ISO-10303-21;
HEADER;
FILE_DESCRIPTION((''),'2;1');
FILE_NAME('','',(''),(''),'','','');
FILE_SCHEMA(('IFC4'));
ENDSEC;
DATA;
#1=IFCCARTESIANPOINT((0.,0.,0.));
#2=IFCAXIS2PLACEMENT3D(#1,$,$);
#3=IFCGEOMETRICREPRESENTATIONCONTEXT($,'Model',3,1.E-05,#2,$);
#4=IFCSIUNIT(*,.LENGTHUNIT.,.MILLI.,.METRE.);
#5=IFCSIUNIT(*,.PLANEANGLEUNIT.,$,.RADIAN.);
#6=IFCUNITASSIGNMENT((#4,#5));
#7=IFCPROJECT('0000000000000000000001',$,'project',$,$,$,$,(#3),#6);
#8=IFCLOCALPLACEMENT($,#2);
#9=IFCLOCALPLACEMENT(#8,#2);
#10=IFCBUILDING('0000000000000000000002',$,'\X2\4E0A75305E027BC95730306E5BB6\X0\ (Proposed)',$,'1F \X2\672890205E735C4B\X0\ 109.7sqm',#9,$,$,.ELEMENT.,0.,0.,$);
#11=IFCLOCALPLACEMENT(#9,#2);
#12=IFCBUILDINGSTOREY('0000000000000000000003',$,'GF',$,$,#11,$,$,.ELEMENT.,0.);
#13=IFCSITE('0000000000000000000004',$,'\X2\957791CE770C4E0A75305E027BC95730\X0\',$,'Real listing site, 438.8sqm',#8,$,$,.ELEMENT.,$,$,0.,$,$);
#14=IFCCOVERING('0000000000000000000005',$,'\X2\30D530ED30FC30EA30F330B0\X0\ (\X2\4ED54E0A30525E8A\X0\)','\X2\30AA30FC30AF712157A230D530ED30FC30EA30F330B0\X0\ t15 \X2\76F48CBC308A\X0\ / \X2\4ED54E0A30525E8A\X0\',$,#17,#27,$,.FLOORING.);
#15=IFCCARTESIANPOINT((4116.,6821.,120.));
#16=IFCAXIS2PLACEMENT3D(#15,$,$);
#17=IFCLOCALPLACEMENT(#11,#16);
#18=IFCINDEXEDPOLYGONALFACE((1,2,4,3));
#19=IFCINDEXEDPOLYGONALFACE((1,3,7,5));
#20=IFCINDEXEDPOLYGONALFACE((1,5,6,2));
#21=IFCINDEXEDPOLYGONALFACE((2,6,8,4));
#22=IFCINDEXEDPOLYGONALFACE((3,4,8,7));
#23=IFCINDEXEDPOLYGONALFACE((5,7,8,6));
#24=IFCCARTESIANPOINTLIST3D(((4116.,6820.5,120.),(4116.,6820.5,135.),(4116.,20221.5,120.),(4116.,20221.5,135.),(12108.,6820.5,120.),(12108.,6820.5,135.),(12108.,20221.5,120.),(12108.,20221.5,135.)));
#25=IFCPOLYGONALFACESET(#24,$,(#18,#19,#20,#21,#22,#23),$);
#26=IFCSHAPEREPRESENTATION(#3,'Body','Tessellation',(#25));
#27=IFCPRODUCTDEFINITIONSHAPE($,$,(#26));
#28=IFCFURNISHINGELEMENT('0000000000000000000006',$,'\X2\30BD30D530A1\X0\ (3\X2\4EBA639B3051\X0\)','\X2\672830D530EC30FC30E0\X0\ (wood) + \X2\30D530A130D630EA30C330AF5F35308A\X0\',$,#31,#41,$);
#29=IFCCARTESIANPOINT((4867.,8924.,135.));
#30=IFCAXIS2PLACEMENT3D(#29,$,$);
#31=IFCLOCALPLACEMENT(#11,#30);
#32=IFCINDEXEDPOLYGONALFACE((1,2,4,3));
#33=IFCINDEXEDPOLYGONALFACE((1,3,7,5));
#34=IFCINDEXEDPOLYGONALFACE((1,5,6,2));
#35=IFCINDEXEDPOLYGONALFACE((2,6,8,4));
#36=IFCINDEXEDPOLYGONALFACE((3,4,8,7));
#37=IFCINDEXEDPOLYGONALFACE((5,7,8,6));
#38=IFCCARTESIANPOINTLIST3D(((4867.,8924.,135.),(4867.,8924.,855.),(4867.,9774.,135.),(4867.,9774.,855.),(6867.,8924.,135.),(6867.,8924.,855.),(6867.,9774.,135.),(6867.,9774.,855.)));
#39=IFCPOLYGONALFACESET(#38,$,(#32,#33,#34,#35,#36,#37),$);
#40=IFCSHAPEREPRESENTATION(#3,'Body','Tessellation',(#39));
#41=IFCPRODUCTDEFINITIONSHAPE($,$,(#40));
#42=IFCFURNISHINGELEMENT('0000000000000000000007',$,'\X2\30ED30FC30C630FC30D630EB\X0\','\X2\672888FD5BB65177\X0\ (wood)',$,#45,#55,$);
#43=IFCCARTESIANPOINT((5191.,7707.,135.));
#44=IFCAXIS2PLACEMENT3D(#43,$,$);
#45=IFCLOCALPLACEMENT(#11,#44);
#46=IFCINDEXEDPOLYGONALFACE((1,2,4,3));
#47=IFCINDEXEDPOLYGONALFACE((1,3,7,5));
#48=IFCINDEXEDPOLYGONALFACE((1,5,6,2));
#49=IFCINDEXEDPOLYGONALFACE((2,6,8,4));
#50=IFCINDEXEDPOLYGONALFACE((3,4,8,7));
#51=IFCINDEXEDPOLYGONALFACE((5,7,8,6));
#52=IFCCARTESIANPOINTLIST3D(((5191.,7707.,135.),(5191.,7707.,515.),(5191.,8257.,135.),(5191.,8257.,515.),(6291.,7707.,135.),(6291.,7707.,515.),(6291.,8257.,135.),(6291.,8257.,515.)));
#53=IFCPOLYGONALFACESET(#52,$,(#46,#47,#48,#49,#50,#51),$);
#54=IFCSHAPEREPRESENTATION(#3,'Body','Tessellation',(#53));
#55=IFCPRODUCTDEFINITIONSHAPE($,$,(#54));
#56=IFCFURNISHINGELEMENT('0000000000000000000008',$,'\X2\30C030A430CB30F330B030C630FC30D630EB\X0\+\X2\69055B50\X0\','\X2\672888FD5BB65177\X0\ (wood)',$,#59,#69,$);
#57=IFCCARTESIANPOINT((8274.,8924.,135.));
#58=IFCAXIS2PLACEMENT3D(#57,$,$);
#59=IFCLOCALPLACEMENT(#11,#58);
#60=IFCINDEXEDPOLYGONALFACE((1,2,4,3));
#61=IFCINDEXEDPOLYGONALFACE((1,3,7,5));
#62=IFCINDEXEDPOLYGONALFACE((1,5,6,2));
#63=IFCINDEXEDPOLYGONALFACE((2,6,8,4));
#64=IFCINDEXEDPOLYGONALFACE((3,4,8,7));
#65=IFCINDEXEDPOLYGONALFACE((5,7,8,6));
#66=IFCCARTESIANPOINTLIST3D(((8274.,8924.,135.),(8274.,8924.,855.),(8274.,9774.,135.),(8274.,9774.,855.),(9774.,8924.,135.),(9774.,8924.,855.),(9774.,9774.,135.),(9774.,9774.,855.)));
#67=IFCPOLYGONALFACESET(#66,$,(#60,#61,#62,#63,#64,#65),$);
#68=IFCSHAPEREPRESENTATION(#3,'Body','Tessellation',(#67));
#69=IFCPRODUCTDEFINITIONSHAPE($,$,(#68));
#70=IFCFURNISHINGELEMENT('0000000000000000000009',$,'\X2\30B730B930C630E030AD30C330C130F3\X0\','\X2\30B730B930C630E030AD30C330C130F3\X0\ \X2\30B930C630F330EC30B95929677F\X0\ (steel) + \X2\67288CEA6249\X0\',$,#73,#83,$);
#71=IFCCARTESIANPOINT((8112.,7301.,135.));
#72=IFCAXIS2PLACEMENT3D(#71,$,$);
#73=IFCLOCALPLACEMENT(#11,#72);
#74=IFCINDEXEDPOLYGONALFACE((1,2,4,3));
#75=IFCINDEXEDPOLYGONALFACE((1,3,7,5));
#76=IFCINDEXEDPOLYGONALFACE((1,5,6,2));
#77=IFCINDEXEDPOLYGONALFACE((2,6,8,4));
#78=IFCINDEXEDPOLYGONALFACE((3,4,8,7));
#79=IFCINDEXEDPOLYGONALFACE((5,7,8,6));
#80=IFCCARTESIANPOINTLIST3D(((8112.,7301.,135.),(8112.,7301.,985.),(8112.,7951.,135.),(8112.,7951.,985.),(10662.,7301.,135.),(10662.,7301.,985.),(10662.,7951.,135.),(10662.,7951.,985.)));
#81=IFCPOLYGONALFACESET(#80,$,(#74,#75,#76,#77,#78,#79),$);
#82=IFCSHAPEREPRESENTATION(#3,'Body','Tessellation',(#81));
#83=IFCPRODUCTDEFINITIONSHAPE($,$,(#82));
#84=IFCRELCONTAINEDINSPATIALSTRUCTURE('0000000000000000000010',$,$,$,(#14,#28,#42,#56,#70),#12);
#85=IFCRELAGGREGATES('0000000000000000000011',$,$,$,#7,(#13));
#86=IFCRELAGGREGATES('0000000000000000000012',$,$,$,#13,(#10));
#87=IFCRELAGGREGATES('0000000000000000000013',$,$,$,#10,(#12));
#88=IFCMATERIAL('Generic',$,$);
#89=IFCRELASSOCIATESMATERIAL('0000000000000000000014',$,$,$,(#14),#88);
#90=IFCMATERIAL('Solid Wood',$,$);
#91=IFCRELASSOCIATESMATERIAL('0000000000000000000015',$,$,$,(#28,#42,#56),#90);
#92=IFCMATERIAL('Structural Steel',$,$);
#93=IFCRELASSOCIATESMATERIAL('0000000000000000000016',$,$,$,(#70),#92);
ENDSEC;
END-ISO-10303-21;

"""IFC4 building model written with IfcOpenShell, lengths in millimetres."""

from ifc_helpers import new_model, si_unit, frame, frame_2d, origin, place, context, project, spatial, rectangle, extrude, material, element, save


model = new_model("IFC4")

# Units and contexts
model_context = context("Model", 3, precision=1e-05, world=origin())
ifc_project = project(units=[si_unit("LENGTHUNIT", "METRE", prefix="MILLI"), si_unit("PLANEANGLEUNIT", "RADIAN")], contexts=[model_context])

# Site, building, storey
site_placement = place(None, origin())
site = spatial("IfcSite", under=ifc_project, at=site_placement, Name="長野県上田市築地", ObjectType="Real listing site, 438.8sqm", CompositionType="ELEMENT", RefElevation=0.0)
building_placement = place(site_placement, origin())
building = spatial("IfcBuilding", under=site, at=building_placement, Name="上田市築地の家 (Proposed)", ObjectType="1F 木造平屋 109.7sqm", CompositionType="ELEMENT", ElevationOfRefHeight=0.0, ElevationOfTerrain=0.0)
storey_placement = place(building_placement, origin())
storey = spatial("IfcBuildingStorey", under=building, at=storey_placement, Name="GF", CompositionType="ELEMENT", Elevation=0.0)

# Shared definitions
ifc_material_1 = material(Name="Solid Wood")

# Shared definitions
ifc_material_2 = material(Name="Structural Steel")

# Covering
ifc_material_3 = material(Name="Generic")
covering_placement = place(storey_placement, frame((4116.0, 6821.0, 120.0)))
element("IfcCovering", 1, at=covering_placement, inside=storey, material=ifc_material_3, Name="フローリング (仕上げ床)", Description="オーク無垢フローリング t15 直貼り / 仕上げ床", PredefinedType="FLOORING", context=model_context, shape_type="SweptSolid", body=[
    extrude(rectangle(XDim=7992.0, YDim=13401.0, at=frame_2d((3996.0, 6700.0))), frame((4116.0, 6821.0, 120.0)), (0.0, 0.0, 1.0), 15.0),
])

# Furnishing elements
furnishing_1_placement = place(storey_placement, frame((4867.0, 8924.0, 135.0)))
element("IfcFurnishingElement", 2, at=furnishing_1_placement, inside=storey, material=ifc_material_1, Name="ソファ (3人掛け)", Description="木フレーム (wood) + ファブリック張り", context=model_context, shape_type="SweptSolid", body=[
    extrude(rectangle(XDim=2000.0, YDim=850.0, at=frame_2d((1000.0, 425.0))), frame((4867.0, 8924.0, 135.0)), (0.0, 0.0, 1.0), 720.0),
])
furnishing_2_placement = place(storey_placement, frame((5191.0, 7707.0, 135.0)))
element("IfcFurnishingElement", 3, at=furnishing_2_placement, inside=storey, material=ifc_material_1, Name="ローテーブル", Description="木製家具 (wood)", context=model_context, shape_type="SweptSolid", body=[
    extrude(rectangle(XDim=1100.0, YDim=550.0, at=frame_2d((550.0, 275.0))), frame((5191.0, 7707.0, 135.0)), (0.0, 0.0, 1.0), 380.0),
])
furnishing_3_placement = place(storey_placement, frame((8274.0, 8924.0, 135.0)))
element("IfcFurnishingElement", 4, at=furnishing_3_placement, inside=storey, material=ifc_material_1, Name="ダイニングテーブル+椅子", Description="木製家具 (wood)", context=model_context, shape_type="SweptSolid", body=[
    extrude(rectangle(XDim=1500.0, YDim=850.0, at=frame_2d((750.0, 425.0))), frame((8274.0, 8924.0, 135.0)), (0.0, 0.0, 1.0), 720.0),
])
furnishing_4_placement = place(storey_placement, frame((8112.0, 7301.0, 135.0)))
element("IfcFurnishingElement", 5, at=furnishing_4_placement, inside=storey, material=ifc_material_2, Name="システムキッチン", Description="システムキッチン ステンレス天板 (steel) + 木質扉", context=model_context, shape_type="SweptSolid", body=[
    extrude(rectangle(XDim=2550.0, YDim=650.0, at=frame_2d((1275.0, 325.0))), frame((8112.0, 7301.0, 135.0)), (0.0, 0.0, 1.0), 850.0),
])

save(model, "model.ifc")
